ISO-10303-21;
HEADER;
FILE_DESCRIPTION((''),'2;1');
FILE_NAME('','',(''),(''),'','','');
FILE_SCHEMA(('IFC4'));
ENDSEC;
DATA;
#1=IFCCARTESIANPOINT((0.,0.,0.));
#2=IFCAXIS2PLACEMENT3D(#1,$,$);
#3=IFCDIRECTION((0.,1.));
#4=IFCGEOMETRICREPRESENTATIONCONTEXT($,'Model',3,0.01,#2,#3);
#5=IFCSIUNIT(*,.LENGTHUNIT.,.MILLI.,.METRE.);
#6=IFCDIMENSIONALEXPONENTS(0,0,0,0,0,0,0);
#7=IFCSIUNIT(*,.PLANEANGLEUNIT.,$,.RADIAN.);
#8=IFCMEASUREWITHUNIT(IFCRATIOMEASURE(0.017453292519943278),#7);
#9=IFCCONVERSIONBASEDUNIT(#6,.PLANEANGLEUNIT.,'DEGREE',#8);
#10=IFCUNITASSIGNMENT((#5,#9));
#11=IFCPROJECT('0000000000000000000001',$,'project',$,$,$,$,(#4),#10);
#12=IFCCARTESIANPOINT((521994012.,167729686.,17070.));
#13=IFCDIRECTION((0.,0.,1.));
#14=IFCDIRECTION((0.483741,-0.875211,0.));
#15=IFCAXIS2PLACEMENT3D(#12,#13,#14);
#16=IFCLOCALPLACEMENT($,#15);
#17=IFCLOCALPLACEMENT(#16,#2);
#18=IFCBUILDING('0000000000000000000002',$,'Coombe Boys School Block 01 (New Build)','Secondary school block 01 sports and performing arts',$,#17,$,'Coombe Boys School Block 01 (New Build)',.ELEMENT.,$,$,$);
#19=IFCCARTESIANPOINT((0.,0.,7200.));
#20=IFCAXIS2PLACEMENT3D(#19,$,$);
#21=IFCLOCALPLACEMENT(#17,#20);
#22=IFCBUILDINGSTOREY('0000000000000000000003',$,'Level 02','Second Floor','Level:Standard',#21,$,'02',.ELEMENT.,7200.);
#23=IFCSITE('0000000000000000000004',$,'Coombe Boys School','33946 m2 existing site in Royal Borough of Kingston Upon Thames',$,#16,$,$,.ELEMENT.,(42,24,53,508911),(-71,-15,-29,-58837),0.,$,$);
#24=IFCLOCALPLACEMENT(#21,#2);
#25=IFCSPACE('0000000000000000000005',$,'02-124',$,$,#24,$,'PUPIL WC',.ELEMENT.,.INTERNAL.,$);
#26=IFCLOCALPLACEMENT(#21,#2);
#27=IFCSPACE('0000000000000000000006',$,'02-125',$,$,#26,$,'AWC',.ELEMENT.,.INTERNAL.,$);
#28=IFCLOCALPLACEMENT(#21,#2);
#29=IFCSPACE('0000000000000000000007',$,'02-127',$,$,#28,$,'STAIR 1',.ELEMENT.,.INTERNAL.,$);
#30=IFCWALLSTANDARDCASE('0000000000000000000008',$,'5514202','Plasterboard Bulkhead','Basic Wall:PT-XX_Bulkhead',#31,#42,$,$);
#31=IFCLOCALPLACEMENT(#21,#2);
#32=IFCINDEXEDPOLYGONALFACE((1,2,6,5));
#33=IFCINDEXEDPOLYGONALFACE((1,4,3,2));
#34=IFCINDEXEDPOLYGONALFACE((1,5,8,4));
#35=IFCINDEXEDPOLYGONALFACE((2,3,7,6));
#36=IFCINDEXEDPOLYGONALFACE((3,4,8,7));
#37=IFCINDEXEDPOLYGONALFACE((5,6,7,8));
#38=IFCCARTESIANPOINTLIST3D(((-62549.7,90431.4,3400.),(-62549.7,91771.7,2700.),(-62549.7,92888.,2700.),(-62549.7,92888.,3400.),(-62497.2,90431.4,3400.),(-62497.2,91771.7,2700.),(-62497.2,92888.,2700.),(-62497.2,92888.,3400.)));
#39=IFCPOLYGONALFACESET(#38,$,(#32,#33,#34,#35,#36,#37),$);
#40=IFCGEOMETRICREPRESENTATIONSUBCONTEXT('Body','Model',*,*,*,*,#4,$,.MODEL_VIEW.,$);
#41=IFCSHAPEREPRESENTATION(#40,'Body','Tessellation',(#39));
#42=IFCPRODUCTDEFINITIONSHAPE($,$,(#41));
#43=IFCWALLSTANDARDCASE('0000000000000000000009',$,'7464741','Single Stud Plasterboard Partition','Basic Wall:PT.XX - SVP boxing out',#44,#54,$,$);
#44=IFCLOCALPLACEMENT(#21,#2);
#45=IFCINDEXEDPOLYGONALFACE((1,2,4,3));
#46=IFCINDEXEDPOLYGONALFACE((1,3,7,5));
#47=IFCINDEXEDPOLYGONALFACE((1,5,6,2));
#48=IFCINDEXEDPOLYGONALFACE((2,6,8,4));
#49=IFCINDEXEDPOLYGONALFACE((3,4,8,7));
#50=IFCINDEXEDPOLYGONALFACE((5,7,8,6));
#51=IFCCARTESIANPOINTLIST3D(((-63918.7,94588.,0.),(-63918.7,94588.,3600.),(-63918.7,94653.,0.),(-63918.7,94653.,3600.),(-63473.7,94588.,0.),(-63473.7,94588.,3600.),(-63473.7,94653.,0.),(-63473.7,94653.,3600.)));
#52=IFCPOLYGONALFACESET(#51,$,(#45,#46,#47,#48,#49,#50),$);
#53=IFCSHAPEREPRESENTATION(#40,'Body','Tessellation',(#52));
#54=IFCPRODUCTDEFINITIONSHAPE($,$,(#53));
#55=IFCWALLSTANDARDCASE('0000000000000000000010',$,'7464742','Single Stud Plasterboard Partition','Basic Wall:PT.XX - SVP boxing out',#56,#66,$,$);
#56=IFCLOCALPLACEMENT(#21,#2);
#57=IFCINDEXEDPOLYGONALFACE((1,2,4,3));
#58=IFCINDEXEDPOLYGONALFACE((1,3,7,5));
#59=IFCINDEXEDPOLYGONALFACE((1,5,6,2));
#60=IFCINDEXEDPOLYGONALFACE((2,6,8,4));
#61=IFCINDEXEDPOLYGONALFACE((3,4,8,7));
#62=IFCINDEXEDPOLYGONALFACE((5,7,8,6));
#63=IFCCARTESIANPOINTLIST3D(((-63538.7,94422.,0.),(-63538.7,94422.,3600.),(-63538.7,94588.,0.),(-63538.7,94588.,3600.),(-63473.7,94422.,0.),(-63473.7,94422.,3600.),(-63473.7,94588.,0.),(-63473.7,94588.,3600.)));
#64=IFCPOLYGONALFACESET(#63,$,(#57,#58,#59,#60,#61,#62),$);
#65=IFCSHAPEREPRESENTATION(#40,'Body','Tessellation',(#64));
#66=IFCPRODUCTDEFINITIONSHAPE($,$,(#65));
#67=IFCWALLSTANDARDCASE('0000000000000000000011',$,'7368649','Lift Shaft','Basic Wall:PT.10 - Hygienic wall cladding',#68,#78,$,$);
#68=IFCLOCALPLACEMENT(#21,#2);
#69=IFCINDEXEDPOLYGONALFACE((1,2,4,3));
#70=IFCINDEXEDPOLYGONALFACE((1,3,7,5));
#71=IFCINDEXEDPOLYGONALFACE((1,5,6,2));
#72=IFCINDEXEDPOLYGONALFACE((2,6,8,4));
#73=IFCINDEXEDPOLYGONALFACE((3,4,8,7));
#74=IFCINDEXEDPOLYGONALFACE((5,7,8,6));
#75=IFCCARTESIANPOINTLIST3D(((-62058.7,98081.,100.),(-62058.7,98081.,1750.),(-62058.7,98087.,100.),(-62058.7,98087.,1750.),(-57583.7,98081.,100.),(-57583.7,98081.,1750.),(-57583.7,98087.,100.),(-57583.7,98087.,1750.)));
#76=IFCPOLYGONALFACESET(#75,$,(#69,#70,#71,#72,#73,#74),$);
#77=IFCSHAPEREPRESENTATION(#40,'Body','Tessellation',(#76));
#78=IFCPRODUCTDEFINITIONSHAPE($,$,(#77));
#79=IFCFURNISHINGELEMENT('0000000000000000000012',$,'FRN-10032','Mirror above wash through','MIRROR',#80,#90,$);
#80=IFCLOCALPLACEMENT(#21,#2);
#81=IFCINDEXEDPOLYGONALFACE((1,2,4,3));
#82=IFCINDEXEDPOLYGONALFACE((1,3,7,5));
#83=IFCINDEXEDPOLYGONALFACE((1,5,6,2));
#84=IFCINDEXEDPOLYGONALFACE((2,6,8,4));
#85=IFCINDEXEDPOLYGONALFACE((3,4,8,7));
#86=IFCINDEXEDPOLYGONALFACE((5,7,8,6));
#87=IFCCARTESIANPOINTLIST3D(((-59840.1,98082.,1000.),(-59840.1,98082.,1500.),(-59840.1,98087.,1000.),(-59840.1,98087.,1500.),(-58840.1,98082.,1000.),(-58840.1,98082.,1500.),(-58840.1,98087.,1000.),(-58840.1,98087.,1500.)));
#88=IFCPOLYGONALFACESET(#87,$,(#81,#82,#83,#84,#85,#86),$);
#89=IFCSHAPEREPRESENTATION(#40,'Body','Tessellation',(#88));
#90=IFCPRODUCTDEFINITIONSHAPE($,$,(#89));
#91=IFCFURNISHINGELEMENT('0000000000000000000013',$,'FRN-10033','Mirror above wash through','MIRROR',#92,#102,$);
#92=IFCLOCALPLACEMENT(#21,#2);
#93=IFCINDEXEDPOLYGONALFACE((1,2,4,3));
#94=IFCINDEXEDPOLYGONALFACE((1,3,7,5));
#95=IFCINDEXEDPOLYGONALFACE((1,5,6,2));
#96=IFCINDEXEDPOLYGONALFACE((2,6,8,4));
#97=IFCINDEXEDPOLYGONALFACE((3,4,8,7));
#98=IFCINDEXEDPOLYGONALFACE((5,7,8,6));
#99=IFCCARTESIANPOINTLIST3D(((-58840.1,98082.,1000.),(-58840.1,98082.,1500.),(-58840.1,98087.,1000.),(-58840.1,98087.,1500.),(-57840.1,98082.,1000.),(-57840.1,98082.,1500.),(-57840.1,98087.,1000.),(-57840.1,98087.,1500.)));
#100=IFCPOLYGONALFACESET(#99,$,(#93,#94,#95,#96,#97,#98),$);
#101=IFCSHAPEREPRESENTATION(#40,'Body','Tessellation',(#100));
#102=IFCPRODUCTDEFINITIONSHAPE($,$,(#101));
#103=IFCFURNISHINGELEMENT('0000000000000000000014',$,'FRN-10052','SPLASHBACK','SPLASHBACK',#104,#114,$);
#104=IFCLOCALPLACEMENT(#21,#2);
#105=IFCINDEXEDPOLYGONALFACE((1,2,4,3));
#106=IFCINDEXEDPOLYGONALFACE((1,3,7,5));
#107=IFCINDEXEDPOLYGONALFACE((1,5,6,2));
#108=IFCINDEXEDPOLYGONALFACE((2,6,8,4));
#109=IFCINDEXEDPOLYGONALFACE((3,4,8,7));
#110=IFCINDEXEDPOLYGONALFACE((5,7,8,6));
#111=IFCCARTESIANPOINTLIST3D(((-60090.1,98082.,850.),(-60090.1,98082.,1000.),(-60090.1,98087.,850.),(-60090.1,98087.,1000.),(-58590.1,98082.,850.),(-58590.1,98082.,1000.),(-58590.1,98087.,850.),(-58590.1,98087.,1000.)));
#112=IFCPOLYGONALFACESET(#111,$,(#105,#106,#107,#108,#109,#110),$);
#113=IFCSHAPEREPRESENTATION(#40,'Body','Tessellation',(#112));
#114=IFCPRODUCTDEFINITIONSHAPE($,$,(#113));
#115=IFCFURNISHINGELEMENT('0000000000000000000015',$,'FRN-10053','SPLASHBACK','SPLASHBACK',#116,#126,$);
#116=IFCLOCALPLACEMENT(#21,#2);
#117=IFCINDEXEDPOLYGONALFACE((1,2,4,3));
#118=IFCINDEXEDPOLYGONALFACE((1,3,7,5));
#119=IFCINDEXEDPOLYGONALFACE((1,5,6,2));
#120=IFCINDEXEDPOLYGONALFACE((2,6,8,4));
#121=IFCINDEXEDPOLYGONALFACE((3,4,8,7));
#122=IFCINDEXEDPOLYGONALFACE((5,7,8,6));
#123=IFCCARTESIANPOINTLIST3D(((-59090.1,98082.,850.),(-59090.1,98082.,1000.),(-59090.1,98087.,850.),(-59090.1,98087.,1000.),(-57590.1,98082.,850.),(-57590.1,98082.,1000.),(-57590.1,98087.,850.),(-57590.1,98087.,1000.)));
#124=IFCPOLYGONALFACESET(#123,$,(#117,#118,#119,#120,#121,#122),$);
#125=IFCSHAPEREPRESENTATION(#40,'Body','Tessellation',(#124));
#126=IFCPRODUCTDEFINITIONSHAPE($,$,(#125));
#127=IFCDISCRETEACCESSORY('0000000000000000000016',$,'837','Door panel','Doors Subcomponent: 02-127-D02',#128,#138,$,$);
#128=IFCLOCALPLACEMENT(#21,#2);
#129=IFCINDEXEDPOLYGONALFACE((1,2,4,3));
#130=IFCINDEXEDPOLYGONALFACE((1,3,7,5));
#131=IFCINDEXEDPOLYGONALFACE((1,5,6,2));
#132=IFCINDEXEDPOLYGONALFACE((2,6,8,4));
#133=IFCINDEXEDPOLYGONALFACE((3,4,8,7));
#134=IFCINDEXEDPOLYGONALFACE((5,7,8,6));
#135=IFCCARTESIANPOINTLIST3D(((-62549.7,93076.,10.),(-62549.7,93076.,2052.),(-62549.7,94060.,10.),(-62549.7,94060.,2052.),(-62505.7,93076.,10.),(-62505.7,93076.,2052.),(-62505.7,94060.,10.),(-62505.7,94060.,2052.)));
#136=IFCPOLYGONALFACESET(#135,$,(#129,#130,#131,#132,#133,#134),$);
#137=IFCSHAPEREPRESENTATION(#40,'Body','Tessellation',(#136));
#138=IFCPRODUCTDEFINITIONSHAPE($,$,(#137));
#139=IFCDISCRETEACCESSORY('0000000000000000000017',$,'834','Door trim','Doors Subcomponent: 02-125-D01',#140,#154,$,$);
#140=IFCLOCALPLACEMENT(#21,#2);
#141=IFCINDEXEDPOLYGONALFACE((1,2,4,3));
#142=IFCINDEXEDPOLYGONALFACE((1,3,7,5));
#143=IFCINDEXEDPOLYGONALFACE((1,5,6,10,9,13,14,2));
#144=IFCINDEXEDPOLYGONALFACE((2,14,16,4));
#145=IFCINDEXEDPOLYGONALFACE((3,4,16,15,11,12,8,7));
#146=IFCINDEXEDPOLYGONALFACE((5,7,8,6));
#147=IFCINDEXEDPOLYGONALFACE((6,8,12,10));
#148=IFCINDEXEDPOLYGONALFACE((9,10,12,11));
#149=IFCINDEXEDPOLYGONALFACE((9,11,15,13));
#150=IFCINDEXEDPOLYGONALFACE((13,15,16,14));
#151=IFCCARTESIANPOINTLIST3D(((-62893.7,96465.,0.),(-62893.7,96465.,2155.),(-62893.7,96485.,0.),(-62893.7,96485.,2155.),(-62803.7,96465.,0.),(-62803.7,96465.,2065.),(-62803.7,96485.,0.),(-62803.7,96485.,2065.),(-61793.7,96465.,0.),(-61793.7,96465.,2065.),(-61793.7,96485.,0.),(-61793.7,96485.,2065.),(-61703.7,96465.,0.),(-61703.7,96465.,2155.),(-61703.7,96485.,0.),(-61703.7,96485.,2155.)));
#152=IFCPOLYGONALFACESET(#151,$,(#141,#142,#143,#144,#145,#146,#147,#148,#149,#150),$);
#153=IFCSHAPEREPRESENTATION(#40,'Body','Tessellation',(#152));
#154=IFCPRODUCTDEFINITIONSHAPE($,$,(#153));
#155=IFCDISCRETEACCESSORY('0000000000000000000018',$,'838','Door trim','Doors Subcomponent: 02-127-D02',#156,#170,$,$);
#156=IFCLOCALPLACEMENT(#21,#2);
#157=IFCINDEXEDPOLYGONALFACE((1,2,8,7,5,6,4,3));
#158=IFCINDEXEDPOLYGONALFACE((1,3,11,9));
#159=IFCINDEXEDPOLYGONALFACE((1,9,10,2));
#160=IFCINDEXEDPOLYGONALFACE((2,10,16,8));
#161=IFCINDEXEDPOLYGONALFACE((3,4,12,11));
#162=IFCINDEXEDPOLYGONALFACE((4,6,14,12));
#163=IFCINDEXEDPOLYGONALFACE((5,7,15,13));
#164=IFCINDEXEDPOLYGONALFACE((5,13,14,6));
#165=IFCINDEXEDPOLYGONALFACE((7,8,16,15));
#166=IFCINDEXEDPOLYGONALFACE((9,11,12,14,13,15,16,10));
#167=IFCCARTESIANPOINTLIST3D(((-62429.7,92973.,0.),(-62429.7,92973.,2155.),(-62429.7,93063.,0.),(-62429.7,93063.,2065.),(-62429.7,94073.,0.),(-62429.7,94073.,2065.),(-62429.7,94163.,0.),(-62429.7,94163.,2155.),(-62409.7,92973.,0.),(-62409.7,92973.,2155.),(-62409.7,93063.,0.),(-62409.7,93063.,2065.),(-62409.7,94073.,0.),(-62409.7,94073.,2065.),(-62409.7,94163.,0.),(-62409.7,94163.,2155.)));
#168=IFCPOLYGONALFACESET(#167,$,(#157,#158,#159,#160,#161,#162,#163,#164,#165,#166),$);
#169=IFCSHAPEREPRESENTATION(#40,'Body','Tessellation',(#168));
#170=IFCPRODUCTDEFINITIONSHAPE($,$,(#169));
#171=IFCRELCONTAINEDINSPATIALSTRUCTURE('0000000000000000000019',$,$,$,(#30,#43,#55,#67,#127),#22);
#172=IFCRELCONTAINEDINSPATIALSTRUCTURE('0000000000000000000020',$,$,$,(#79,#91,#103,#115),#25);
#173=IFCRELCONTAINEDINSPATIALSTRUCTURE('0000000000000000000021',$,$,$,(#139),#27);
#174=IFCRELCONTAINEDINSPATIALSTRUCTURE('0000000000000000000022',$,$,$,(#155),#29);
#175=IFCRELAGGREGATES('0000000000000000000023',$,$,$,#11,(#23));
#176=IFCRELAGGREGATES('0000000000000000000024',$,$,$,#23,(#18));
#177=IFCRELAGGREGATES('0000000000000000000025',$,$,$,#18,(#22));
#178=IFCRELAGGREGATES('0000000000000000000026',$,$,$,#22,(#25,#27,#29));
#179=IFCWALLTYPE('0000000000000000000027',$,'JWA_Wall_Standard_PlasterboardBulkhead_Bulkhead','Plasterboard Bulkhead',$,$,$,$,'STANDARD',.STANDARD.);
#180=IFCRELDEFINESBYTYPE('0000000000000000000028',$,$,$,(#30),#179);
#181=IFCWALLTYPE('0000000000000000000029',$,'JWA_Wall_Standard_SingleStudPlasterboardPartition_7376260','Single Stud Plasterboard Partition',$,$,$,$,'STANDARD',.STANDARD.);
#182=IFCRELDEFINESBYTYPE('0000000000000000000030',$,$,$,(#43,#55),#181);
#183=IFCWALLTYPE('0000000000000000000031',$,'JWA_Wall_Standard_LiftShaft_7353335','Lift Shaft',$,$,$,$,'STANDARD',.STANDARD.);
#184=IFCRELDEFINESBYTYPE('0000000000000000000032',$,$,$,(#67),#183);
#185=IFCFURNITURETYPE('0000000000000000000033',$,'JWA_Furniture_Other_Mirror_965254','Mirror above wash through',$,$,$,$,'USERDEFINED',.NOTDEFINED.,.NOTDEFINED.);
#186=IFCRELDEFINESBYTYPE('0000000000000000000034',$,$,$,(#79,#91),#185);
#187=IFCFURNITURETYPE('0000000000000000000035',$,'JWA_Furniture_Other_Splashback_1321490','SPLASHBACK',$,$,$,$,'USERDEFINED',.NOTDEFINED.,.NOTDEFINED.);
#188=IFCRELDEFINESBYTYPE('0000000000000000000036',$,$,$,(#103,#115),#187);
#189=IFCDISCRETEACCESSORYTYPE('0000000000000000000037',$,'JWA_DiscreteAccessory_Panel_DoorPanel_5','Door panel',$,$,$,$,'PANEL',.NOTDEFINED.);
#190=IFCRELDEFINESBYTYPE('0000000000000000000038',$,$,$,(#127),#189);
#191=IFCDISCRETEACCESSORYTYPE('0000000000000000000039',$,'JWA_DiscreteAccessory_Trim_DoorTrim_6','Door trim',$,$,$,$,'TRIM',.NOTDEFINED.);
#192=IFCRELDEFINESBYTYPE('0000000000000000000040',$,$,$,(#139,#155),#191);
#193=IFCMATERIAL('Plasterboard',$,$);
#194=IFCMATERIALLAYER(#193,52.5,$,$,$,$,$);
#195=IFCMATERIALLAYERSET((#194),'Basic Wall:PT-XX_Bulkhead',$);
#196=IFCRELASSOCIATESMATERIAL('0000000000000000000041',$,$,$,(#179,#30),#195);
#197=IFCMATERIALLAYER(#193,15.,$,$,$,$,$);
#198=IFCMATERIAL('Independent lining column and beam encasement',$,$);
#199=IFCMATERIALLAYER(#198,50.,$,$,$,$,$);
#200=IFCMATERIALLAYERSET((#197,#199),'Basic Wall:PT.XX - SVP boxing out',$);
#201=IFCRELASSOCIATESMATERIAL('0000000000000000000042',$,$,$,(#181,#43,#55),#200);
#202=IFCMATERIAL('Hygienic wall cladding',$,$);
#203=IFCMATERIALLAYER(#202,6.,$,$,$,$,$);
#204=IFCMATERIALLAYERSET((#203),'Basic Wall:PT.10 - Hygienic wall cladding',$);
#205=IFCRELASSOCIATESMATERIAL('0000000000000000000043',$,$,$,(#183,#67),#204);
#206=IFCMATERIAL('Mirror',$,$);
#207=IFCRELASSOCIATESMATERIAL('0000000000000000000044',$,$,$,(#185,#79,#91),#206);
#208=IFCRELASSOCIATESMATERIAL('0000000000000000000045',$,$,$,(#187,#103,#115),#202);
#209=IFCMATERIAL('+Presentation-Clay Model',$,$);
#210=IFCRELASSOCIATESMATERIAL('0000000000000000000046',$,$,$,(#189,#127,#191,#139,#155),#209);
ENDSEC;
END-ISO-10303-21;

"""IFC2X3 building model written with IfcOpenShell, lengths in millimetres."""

from ifc_helpers import new_model, entity, si_unit, converted_unit, direction, frame, frame_2d, origin, origin_2d_with_axis, place, context, subcontext, project, spatial, polyline, rectangle, outline, extrude, clip, halfspace, source, transform, mapped, material, layer, layer_set, layer_usage, type_object, type_shapes, element, save


model = new_model("IFC2X3")

# Units and contexts
model_context = context("Model", 3, precision=0.01, world=origin(), true_north=direction((0.0, 1.0)))
body_context = subcontext(model_context, "Body", "Model", "MODEL_VIEW")
ifc_project = project(units=[si_unit("LENGTHUNIT", "METRE", prefix="MILLI"), converted_unit("PLANEANGLEUNIT", "DEGREE", entity("IfcRatioMeasure", 0.017453292519943278), si_unit("PLANEANGLEUNIT", "RADIAN"), dimensions=[0, 0, 0, 0, 0, 0, 0])], contexts=[model_context])

# Site, building, storey
site_placement = place(None, frame((521994012.0, 167729686.0, 17070.0), z_axis=(0.0, 0.0, 1.0), x_axis=(0.483741, -0.875211, 0.0)))
site = spatial("IfcSite", under=ifc_project, at=site_placement, Name="Coombe Boys School", Description="33946 m2 existing site in Royal Borough of Kingston Upon Thames", CompositionType="ELEMENT", RefLatitude=(42, 24, 53, 508911), RefLongitude=(-71, -15, -29, -58837), RefElevation=0.0)
building_placement = place(site_placement, origin())
building = spatial("IfcBuilding", under=site, at=building_placement, Name="Coombe Boys School Block 01 (New Build)", Description="Secondary school block 01 sports and performing arts", LongName="Coombe Boys School Block 01 (New Build)", CompositionType="ELEMENT")
storey_placement = place(building_placement, frame((0.0, 0.0, 7200.0)))
storey = spatial("IfcBuildingStorey", under=building, at=storey_placement, Name="Level 02", Description="Second Floor", ObjectType="Level:Standard", LongName="02", CompositionType="ELEMENT", Elevation=7200.0)

# Shared definitions
ifc_material_1 = material(Name="Plasterboard")

# Walls
ifc_layer_1 = layer(ifc_material_1, 52.5)
ifc_layer_set_1 = layer_set([ifc_layer_1], Name="Basic Wall:PT-XX_Bulkhead")
ifc_layer_usage_1 = layer_usage(ifc_layer_set_1, "AXIS2", "NEGATIVE", 26.2)
wall_type_1 = type_object("IfcWallType", Name="JWA_Wall_Standard_PlasterboardBulkhead_Bulkhead", Description="Plasterboard Bulkhead", ElementType="STANDARD", PredefinedType="STANDARD", material=ifc_layer_set_1)
wall_1_placement = place(storey_placement, frame((-62523.5, 90431.4, 2700.0), z_axis=(0.0, 0.0, 1.0), x_axis=(0.0, 1.0, 0.0)))
element("IfcWallStandardCase", 1, at=wall_1_placement, inside=storey, type_object=wall_type_1, material=ifc_layer_usage_1, Name="5514202", Description="Plasterboard Bulkhead", ObjectType="Basic Wall:PT-XX_Bulkhead", context=body_context, shape_type="Clipping", body=[
    clip(extrude(rectangle(XDim=2456.6, YDim=52.5, at=frame_2d((1228.3, 0.0), x_axis=(-1.0, 0.0))), origin(), (0.0, 0.0, 1.0), 700.0), halfspace(frame((1340.3, -26.2, 0.0), z_axis=(-0.462932, 0.0, -0.886394), x_axis=(0.0, 1.0, 0.0)), False)),
])
ifc_layer_2 = layer(ifc_material_1, 15.0)
ifc_material_2 = material(Name="Independent lining column and beam encasement")
ifc_layer_3 = layer(ifc_material_2, 50.0)
ifc_layer_set_2 = layer_set([ifc_layer_2, ifc_layer_3], Name="Basic Wall:PT.XX - SVP boxing out")
ifc_layer_usage_2 = layer_usage(ifc_layer_set_2, "AXIS2", "NEGATIVE", 32.5)
wall_type_2 = type_object("IfcWallType", Name="JWA_Wall_Standard_SingleStudPlasterboardPartition_7376260", Description="Single Stud Plasterboard Partition", ElementType="STANDARD", PredefinedType="STANDARD", material=ifc_layer_set_2)
wall_2_placement = place(storey_placement, frame((-63918.7, 94620.5, 0.0)))
element("IfcWallStandardCase", 2, at=wall_2_placement, inside=storey, type_object=wall_type_2, material=ifc_layer_usage_2, Name="7464741", Description="Single Stud Plasterboard Partition", ObjectType="Basic Wall:PT.XX - SVP boxing out", context=body_context, shape_type="SweptSolid", body=[
    extrude(rectangle(XDim=445.0, YDim=65.0, at=frame_2d((222.5, 0.0), x_axis=(-1.0, 0.0))), origin(), (0.0, 0.0, 1.0), 3600.0),
])
wall_3_placement = place(storey_placement, frame((-63506.2, 94588.0, 0.0), z_axis=(0.0, 0.0, 1.0), x_axis=(0.0, -1.0, 0.0)))
element("IfcWallStandardCase", 3, at=wall_3_placement, inside=storey, type_object=wall_type_2, material=ifc_layer_usage_2, Name="7464742", Description="Single Stud Plasterboard Partition", ObjectType="Basic Wall:PT.XX - SVP boxing out", context=body_context, shape_type="SweptSolid", body=[
    extrude(rectangle(XDim=166.0, YDim=65.0, at=frame_2d((83.0, 0.0), x_axis=(-1.0, 0.0))), origin(), (0.0, 0.0, 1.0), 3600.0),
])
ifc_material_3 = material(Name="Hygienic wall cladding")
ifc_layer_4 = layer(ifc_material_3, 6.0)
ifc_layer_set_3 = layer_set([ifc_layer_4], Name="Basic Wall:PT.10 - Hygienic wall cladding")
ifc_layer_usage_3 = layer_usage(ifc_layer_set_3, "AXIS2", "NEGATIVE", 3.0)
wall_type_3 = type_object("IfcWallType", Name="JWA_Wall_Standard_LiftShaft_7353335", Description="Lift Shaft", ElementType="STANDARD", PredefinedType="STANDARD", material=ifc_layer_set_3)
wall_4_placement = place(storey_placement, frame((-57583.7, 98084.0, 100.0), z_axis=(0.0, 0.0, 1.0), x_axis=(-1.0, 0.0, 0.0)))
element("IfcWallStandardCase", 4, at=wall_4_placement, inside=storey, type_object=wall_type_3, material=ifc_layer_usage_3, Name="7368649", Description="Lift Shaft", ObjectType="Basic Wall:PT.10 - Hygienic wall cladding", context=body_context, shape_type="SweptSolid", body=[
    extrude(rectangle(XDim=4475.0, YDim=6.0, at=frame_2d((2237.5, 0.0), x_axis=(-1.0, 0.0))), origin(), (0.0, 0.0, 1.0), 1650.0),
])

# Shared definitions
space_1_placement = place(storey_placement, origin())
space_1 = spatial("IfcSpace", under=storey, at=space_1_placement, Name="02-124", LongName="PUPIL WC", CompositionType="ELEMENT", InteriorOrExteriorSpace="INTERNAL")

# Furnishing elements
ifc_material_4 = material(Name="Mirror")
furniture_type_1 = type_object("IfcFurnitureType", Name="JWA_Furniture_Other_Mirror_965254", Description="Mirror above wash through", ElementType="USERDEFINED", material=ifc_material_4)
shared_shape_1 = source(origin(), body_context, "Body", "SweptSolid", [
    extrude(rectangle(XDim=5.0, YDim=1000.0, at=origin_2d_with_axis()), frame((0.0, -2.5, 0.0), z_axis=(0.0, 0.0, 1.0), x_axis=(0.0, 1.0, 0.0)), (0.0, 0.0, 1.0), 500.0),
])
type_shapes(furniture_type_1, [shared_shape_1])
for number, where, name in (
    (5, (-59340.1, 98087.0, 1000.0), "FRN-10032"),
    (6, (-58340.1, 98087.0, 1000.0), "FRN-10033"),
):
    element("IfcFurnishingElement", number, at=place(space_1_placement, frame(where)), inside=space_1, type_object=furniture_type_1, material=ifc_material_4, Name=name, Description="Mirror above wash through", ObjectType="MIRROR", context=body_context, shape_type="MappedRepresentation", body=[
        mapped(shared_shape_1, transform((0.0, 0.0, 0.0), scale=1.0)),
    ])
furniture_type_2 = type_object("IfcFurnitureType", Name="JWA_Furniture_Other_Splashback_1321490", Description="SPLASHBACK", ElementType="USERDEFINED", material=ifc_material_3)
shared_shape_2 = source(origin(), body_context, "Body", "SweptSolid", [
    extrude(rectangle(XDim=5.0, YDim=1500.0, at=origin_2d_with_axis()), frame((0.0, -2.5, 0.0), z_axis=(0.0, 0.0, 1.0), x_axis=(0.0, 1.0, 0.0)), (0.0, 0.0, 1.0), 150.0),
])
type_shapes(furniture_type_2, [shared_shape_2])
for number, where, name in (
    (7, (-59340.1, 98087.0, 850.0), "FRN-10052"),
    (8, (-58340.1, 98087.0, 850.0), "FRN-10053"),
):
    element("IfcFurnishingElement", number, at=place(space_1_placement, frame(where)), inside=space_1, type_object=furniture_type_2, material=ifc_material_3, Name=name, Description="SPLASHBACK", ObjectType="SPLASHBACK", context=body_context, shape_type="MappedRepresentation", body=[
        mapped(shared_shape_2, transform((0.0, 0.0, 0.0), scale=1.0)),
    ])

# Shared definitions
space_2_placement = place(storey_placement, origin())
space_2 = spatial("IfcSpace", under=storey, at=space_2_placement, Name="02-125", LongName="AWC", CompositionType="ELEMENT", InteriorOrExteriorSpace="INTERNAL")

# Discrete accessories
ifc_material_5 = material(Name="+Presentation-Clay Model")
discrete_accessory_type_1 = type_object("IfcDiscreteAccessoryType", Name="JWA_DiscreteAccessory_Panel_DoorPanel_5", Description="Door panel", ElementType="PANEL", material=ifc_material_5)
shared_shape_3 = source(origin(), body_context, "Body", "SweptSolid", [
    extrude(rectangle(XDim=44.0, YDim=984.0, at=origin_2d_with_axis()), frame((0.0, 22.0, 10.0), z_axis=(0.0, 0.0, 1.0), x_axis=(0.0, -1.0, 0.0)), (0.0, 0.0, 1.0), 2042.0),
])
type_shapes(discrete_accessory_type_1, [shared_shape_3])
discrete_accessory_1_placement = place(storey_placement, frame((-62505.7, 93568.0, 0.0), z_axis=(0.0, 0.0, 1.0), x_axis=(0.0, 1.0, 0.0)))
element("IfcDiscreteAccessory", 9, at=discrete_accessory_1_placement, inside=storey, type_object=discrete_accessory_type_1, material=ifc_material_5, Name="837", Description="Door panel", ObjectType="Doors Subcomponent: 02-127-D02", context=body_context, shape_type="MappedRepresentation", body=[
    mapped(shared_shape_3, transform((0.0, 0.0, 0.0), scale=1.0)),
])
discrete_accessory_type_2 = type_object("IfcDiscreteAccessoryType", Name="JWA_DiscreteAccessory_Trim_DoorTrim_6", Description="Door trim", ElementType="TRIM", material=ifc_material_5)
shared_shape_4 = source(origin(), body_context, "Body", "SweptSolid", [
    extrude(outline(polyline([(-1055.0, -595.0), (1100.0, -595.0), (1100.0, 595.0), (-1055.0, 595.0), (-1055.0, 505.0), (1010.0, 505.0), (1010.0, -505.0), (-1055.0, -505.0), (-1055.0, -595.0)])), frame((0.0, -20.0, 1055.0), z_axis=(0.0, 1.0, 0.0), x_axis=(0.0, 0.0, 1.0)), (0.0, 0.0, 1.0), 20.0),
])
type_shapes(discrete_accessory_type_2, [shared_shape_4])
discrete_accessory_2_placement = place(space_2_placement, frame((-62298.7, 96485.0, 0.0)))
element("IfcDiscreteAccessory", 10, at=discrete_accessory_2_placement, inside=space_2, type_object=discrete_accessory_type_2, material=ifc_material_5, Name="834", Description="Door trim", ObjectType="Doors Subcomponent: 02-125-D01", context=body_context, shape_type="MappedRepresentation", body=[
    mapped(shared_shape_4, transform((0.0, 0.0, 0.0), scale=1.0)),
])

# Shared definitions
space_3_placement = place(storey_placement, origin())
space_3 = spatial("IfcSpace", under=storey, at=space_3_placement, Name="02-127", LongName="STAIR 1", CompositionType="ELEMENT", InteriorOrExteriorSpace="INTERNAL")

# Discrete accessory
discrete_accessory_3_placement = place(space_3_placement, frame((-62429.7, 93568.0, 0.0), z_axis=(0.0, 0.0, 1.0), x_axis=(0.0, 1.0, 0.0)))
element("IfcDiscreteAccessory", 11, at=discrete_accessory_3_placement, inside=space_3, type_object=discrete_accessory_type_2, material=ifc_material_5, Name="838", Description="Door trim", ObjectType="Doors Subcomponent: 02-127-D02", context=body_context, shape_type="MappedRepresentation", body=[
    mapped(shared_shape_4, transform((0.0, 0.0, 0.0), scale=1.0)),
])

save(model, "model.ifc")
